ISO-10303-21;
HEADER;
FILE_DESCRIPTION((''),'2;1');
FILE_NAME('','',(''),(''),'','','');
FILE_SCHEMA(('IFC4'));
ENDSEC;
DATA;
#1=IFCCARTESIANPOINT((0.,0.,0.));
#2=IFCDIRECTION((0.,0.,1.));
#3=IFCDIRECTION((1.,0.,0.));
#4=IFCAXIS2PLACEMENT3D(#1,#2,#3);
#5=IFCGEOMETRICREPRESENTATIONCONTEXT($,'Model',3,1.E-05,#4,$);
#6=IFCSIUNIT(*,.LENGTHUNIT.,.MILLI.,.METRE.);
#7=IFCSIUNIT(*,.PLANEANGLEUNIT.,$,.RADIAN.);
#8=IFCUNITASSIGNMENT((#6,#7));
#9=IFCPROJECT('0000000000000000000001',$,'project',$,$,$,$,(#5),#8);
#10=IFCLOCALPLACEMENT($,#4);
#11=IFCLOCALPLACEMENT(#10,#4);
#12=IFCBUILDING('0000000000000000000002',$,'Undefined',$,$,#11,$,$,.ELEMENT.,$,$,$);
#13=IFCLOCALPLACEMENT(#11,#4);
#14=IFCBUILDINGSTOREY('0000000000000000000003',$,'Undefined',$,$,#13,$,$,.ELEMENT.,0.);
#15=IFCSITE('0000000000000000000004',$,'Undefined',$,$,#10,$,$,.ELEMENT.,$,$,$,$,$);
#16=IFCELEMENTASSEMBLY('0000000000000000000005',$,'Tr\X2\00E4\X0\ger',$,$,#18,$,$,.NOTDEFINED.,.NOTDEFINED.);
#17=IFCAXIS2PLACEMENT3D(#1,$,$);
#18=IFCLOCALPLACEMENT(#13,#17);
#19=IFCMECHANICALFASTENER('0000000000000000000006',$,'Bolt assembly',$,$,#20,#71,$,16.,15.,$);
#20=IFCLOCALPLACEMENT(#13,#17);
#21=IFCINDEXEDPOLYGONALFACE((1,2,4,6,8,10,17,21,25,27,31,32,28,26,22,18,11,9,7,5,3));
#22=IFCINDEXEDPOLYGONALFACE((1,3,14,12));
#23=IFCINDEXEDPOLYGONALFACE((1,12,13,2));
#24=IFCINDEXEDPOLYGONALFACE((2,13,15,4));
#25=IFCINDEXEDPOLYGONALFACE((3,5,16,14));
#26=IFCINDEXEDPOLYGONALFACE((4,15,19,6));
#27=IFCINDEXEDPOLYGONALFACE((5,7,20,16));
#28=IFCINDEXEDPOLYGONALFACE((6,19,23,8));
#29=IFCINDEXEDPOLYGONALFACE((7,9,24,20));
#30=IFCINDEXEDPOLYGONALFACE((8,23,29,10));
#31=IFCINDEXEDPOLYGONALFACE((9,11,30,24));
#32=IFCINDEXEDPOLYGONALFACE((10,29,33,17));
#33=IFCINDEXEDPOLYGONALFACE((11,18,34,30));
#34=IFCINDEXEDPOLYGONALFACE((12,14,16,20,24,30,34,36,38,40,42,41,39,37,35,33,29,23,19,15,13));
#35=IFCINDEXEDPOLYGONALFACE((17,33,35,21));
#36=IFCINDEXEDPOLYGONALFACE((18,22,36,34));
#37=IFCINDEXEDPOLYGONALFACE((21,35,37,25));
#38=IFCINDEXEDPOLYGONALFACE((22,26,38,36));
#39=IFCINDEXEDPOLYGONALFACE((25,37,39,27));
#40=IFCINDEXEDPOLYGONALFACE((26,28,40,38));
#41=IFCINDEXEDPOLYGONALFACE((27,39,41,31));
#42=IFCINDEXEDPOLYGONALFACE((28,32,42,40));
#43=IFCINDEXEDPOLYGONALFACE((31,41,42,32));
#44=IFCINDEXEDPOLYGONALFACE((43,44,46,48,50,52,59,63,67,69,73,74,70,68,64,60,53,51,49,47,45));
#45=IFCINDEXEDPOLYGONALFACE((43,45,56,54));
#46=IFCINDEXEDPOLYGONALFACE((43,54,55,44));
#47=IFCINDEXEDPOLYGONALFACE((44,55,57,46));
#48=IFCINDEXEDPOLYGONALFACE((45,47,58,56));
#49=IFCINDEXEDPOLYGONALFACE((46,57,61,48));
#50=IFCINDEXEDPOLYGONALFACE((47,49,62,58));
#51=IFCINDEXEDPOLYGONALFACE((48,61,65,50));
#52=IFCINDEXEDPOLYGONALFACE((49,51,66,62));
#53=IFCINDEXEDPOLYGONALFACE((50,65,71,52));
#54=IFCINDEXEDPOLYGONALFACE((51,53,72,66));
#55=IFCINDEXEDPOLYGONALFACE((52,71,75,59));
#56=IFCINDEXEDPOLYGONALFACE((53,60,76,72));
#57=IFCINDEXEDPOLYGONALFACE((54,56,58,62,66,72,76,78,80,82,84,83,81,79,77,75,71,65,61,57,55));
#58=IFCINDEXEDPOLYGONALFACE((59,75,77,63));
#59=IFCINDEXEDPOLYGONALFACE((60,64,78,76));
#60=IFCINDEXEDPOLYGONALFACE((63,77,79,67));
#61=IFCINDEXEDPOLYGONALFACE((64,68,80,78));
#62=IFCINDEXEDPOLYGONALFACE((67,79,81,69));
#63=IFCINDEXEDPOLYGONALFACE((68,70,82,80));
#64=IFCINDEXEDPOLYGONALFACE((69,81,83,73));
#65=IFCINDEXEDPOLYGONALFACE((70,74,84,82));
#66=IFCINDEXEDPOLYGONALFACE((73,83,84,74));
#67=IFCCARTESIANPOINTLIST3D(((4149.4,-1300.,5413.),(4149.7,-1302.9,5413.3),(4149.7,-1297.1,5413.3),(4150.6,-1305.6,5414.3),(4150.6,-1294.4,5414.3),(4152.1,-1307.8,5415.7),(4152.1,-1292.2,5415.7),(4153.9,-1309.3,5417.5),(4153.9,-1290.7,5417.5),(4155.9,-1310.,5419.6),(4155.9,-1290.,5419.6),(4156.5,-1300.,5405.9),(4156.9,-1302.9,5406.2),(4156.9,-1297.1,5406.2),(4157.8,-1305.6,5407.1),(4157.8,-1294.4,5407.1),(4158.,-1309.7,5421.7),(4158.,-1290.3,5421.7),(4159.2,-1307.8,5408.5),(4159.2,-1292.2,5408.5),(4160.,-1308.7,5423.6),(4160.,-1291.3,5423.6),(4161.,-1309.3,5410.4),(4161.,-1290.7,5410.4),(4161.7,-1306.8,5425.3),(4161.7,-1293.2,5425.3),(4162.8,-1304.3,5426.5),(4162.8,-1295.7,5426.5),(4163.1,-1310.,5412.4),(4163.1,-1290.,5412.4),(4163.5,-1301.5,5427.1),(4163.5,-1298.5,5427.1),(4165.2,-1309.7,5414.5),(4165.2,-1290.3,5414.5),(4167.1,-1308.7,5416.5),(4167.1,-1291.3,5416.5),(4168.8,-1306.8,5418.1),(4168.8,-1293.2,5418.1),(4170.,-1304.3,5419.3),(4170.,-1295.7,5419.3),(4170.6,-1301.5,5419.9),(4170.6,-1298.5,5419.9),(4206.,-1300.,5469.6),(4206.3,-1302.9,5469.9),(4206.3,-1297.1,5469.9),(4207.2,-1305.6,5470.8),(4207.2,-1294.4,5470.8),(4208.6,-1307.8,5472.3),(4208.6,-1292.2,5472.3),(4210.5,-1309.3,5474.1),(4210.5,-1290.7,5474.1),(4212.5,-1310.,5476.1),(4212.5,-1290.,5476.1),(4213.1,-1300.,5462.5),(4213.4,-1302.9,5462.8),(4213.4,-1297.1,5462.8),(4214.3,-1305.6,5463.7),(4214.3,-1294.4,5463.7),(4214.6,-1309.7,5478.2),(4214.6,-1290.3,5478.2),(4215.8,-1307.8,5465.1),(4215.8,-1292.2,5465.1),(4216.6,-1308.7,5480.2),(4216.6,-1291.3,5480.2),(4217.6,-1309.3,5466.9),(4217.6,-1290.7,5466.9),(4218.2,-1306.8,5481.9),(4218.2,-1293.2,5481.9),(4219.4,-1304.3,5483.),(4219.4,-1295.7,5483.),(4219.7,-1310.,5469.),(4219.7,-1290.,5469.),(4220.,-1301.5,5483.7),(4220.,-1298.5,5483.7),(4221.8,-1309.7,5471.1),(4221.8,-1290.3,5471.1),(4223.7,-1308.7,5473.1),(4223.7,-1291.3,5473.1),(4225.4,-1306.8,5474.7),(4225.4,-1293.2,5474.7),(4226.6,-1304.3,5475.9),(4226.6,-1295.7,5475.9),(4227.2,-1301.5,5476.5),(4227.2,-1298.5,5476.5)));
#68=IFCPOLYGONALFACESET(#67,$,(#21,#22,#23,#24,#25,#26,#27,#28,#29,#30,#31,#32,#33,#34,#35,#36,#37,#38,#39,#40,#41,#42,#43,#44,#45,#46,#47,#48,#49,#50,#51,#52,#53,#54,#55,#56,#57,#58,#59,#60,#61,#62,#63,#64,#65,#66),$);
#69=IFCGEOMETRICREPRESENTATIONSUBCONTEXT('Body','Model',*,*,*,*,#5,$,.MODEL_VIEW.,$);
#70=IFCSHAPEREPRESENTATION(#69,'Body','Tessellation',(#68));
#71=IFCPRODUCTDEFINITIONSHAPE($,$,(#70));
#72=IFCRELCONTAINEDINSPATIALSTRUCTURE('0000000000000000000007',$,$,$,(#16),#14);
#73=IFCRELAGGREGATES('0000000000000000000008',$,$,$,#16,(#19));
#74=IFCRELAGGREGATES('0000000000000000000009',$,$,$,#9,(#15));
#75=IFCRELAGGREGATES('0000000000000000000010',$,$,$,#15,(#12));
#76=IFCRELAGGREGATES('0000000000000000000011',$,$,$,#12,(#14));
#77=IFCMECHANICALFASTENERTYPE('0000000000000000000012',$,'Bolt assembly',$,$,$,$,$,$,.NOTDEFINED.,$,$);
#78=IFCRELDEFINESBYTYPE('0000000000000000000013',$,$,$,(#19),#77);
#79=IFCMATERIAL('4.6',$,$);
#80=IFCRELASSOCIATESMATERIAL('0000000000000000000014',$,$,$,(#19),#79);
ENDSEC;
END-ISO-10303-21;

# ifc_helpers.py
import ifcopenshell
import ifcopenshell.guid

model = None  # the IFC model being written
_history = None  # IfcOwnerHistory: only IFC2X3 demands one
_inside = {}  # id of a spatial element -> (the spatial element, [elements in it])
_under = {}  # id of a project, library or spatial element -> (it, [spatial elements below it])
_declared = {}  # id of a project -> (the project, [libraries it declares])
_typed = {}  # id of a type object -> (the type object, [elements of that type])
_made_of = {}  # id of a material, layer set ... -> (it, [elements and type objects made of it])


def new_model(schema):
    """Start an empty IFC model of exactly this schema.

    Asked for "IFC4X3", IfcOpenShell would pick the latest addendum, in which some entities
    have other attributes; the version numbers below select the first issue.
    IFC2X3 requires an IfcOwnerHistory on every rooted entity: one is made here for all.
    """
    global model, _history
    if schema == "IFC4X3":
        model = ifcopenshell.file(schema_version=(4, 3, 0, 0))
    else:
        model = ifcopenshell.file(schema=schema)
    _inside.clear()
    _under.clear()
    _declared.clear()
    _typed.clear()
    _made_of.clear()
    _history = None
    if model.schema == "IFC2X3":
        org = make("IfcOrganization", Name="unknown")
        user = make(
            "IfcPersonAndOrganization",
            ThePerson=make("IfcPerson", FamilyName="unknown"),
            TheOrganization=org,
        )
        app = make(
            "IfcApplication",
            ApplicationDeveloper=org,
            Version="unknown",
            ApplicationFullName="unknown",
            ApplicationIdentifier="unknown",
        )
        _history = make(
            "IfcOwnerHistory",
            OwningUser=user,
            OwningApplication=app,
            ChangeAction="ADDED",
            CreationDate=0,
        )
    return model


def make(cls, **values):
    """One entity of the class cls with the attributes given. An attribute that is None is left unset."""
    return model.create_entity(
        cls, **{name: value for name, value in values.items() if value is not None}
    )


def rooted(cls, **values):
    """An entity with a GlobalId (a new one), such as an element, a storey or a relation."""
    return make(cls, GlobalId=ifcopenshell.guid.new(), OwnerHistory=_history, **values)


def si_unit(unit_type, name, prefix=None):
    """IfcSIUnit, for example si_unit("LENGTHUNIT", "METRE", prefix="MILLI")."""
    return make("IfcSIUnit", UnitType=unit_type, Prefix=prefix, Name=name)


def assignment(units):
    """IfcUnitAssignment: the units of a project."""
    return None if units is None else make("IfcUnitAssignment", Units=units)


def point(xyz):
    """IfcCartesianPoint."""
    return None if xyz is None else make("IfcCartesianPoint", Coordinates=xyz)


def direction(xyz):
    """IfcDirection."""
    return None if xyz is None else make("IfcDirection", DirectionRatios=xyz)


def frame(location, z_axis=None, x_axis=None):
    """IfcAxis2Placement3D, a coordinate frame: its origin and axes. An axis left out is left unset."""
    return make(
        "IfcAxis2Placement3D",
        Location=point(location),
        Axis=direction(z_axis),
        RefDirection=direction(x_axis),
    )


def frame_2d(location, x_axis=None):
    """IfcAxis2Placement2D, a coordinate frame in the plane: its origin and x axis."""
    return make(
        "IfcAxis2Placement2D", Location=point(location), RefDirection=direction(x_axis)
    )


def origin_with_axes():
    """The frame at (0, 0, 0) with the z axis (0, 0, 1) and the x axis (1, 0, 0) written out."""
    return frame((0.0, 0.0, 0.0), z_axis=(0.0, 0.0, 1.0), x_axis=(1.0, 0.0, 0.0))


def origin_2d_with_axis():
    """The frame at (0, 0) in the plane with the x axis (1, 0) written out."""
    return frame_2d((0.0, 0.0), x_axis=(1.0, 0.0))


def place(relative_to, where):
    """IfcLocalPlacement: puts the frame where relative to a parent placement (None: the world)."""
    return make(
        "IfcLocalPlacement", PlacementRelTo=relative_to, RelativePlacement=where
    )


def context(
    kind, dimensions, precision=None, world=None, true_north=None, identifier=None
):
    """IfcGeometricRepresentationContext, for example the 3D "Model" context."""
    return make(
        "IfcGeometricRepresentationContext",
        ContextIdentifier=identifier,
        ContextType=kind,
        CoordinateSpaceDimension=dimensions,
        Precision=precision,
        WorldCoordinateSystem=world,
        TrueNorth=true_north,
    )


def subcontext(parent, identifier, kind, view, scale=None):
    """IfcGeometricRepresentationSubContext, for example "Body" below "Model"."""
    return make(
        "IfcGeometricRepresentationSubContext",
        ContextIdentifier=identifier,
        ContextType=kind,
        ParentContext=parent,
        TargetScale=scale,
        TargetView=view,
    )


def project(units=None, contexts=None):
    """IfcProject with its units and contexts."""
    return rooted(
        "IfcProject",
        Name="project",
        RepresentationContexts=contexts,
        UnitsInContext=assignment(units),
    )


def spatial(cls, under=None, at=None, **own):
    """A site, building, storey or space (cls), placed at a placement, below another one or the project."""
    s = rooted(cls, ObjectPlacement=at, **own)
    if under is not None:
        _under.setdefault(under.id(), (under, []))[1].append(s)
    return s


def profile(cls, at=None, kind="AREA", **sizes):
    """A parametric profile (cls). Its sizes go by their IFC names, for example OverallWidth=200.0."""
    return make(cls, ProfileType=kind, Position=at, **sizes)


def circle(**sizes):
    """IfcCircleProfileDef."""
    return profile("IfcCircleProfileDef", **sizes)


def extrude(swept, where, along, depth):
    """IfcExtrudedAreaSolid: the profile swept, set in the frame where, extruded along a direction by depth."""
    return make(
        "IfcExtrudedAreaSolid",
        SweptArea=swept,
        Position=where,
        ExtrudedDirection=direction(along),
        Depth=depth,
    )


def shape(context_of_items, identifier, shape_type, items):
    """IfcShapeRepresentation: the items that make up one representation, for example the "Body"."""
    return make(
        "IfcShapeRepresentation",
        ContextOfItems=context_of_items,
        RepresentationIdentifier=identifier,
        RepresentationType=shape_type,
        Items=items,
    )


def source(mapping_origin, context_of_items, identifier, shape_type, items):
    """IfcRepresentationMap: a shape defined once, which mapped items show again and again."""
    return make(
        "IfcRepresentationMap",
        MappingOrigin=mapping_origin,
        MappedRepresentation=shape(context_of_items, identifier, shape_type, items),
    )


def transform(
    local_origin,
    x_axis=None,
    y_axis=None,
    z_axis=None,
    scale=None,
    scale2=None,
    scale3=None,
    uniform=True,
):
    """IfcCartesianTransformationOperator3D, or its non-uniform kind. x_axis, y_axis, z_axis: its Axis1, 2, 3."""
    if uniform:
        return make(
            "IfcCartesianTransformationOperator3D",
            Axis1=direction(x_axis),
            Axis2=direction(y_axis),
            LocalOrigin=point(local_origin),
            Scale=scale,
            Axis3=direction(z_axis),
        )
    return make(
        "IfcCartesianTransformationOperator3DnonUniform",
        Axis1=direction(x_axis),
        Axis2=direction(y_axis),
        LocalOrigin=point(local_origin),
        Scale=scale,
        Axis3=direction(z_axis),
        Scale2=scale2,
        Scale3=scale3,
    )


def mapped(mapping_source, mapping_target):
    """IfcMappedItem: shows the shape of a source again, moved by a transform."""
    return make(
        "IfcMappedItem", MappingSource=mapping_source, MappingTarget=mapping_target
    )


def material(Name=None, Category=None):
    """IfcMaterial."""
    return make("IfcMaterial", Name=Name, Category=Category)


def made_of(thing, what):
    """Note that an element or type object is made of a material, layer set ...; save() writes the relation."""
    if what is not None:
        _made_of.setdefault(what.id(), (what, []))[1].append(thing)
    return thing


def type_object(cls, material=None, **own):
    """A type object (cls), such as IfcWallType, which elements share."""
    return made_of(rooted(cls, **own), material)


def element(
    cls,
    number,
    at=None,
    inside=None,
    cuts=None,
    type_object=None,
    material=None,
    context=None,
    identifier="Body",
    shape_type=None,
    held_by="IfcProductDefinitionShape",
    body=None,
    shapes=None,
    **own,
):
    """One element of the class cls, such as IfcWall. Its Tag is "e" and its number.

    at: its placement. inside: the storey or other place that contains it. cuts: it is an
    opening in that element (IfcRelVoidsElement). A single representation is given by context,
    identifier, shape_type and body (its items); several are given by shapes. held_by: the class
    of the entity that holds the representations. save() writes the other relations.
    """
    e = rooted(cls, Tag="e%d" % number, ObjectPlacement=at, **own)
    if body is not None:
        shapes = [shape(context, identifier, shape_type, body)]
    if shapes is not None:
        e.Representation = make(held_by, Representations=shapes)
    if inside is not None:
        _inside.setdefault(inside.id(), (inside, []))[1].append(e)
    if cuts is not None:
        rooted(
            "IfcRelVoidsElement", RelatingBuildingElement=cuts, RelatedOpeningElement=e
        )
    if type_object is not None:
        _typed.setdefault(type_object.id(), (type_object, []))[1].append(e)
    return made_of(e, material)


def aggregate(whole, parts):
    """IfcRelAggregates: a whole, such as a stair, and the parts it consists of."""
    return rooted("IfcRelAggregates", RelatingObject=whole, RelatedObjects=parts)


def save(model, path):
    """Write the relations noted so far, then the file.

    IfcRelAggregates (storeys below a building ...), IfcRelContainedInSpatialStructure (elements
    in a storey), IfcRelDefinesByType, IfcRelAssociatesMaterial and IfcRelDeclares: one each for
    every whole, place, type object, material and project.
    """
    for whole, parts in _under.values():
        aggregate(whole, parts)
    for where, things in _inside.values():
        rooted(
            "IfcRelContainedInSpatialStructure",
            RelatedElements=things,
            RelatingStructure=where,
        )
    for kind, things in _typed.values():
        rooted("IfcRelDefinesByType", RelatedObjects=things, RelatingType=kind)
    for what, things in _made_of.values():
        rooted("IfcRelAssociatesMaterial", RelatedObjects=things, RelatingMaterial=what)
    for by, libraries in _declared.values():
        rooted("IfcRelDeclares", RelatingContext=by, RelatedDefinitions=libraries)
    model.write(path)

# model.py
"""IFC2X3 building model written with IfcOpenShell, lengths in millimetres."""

from ifc_helpers import new_model, si_unit, frame, origin_with_axes, origin_2d_with_axis, place, context, subcontext, project, spatial, circle, extrude, source, transform, mapped, material, type_object, element, aggregate, save


model = new_model("IFC2X3")

# Units and contexts
model_context = context("Model", 3, precision=1e-05, world=origin_with_axes())
body_context = subcontext(model_context, "Body", "Model", "MODEL_VIEW")
ifc_project = project(units=[si_unit("LENGTHUNIT", "METRE", prefix="MILLI"), si_unit("PLANEANGLEUNIT", "RADIAN")], contexts=[model_context])

# Site, building, storey
site_placement = place(None, origin_with_axes())
site = spatial("IfcSite", under=ifc_project, at=site_placement, Name="Undefined", CompositionType="ELEMENT")
building_placement = place(site_placement, origin_with_axes())
building = spatial("IfcBuilding", under=site, at=building_placement, Name="Undefined", CompositionType="ELEMENT")
storey_placement = place(building_placement, origin_with_axes())
storey = spatial("IfcBuildingStorey", under=building, at=storey_placement, Name="Undefined", CompositionType="ELEMENT", Elevation=0.0)

# Element assembly
assembly_1_placement = place(storey_placement, origin_with_axes())
assembly_1 = element("IfcElementAssembly", 1, at=assembly_1_placement, inside=storey, Name="Träger", AssemblyPlace="NOTDEFINED", PredefinedType="NOTDEFINED")

# Mechanical fastener
ifc_material_1 = material(Name="4.6")
mechanical_fastener_type = type_object("IfcMechanicalFastenerType", Name="Bolt assembly")
shared_shape_1 = source(origin_with_axes(), body_context, "Body", "SweptSolid", [
    extrude(circle(Radius=10.0, at=origin_2d_with_axis()), frame((0.0, 0.0, 0.0), z_axis=(0.0, 1.0, 0.0), x_axis=(1.0, 0.0, 0.0)), (0.0, 0.0, 1.0), 10.1),
])
mechanical_fastener_1_placement = place(assembly_1_placement, frame((4213.0, -1300.0, 5476.7), z_axis=(0.0, -1.0, 0.0), x_axis=(-0.707107, 0.0, -0.707107)))
mechanical_fastener_1 = element("IfcMechanicalFastener", 2, at=mechanical_fastener_1_placement, type_object=mechanical_fastener_type, material=ifc_material_1, Name="Bolt assembly", NominalDiameter=16.0, NominalLength=15.0, context=body_context, shape_type="MappedRepresentation", body=[
    mapped(shared_shape_1, transform((0.0, 0.0, 0.0))),
    mapped(shared_shape_1, transform((80.0, 0.0, 0.0))),
])
aggregate(assembly_1, [mechanical_fastener_1])

save(model, "model.ifc")
